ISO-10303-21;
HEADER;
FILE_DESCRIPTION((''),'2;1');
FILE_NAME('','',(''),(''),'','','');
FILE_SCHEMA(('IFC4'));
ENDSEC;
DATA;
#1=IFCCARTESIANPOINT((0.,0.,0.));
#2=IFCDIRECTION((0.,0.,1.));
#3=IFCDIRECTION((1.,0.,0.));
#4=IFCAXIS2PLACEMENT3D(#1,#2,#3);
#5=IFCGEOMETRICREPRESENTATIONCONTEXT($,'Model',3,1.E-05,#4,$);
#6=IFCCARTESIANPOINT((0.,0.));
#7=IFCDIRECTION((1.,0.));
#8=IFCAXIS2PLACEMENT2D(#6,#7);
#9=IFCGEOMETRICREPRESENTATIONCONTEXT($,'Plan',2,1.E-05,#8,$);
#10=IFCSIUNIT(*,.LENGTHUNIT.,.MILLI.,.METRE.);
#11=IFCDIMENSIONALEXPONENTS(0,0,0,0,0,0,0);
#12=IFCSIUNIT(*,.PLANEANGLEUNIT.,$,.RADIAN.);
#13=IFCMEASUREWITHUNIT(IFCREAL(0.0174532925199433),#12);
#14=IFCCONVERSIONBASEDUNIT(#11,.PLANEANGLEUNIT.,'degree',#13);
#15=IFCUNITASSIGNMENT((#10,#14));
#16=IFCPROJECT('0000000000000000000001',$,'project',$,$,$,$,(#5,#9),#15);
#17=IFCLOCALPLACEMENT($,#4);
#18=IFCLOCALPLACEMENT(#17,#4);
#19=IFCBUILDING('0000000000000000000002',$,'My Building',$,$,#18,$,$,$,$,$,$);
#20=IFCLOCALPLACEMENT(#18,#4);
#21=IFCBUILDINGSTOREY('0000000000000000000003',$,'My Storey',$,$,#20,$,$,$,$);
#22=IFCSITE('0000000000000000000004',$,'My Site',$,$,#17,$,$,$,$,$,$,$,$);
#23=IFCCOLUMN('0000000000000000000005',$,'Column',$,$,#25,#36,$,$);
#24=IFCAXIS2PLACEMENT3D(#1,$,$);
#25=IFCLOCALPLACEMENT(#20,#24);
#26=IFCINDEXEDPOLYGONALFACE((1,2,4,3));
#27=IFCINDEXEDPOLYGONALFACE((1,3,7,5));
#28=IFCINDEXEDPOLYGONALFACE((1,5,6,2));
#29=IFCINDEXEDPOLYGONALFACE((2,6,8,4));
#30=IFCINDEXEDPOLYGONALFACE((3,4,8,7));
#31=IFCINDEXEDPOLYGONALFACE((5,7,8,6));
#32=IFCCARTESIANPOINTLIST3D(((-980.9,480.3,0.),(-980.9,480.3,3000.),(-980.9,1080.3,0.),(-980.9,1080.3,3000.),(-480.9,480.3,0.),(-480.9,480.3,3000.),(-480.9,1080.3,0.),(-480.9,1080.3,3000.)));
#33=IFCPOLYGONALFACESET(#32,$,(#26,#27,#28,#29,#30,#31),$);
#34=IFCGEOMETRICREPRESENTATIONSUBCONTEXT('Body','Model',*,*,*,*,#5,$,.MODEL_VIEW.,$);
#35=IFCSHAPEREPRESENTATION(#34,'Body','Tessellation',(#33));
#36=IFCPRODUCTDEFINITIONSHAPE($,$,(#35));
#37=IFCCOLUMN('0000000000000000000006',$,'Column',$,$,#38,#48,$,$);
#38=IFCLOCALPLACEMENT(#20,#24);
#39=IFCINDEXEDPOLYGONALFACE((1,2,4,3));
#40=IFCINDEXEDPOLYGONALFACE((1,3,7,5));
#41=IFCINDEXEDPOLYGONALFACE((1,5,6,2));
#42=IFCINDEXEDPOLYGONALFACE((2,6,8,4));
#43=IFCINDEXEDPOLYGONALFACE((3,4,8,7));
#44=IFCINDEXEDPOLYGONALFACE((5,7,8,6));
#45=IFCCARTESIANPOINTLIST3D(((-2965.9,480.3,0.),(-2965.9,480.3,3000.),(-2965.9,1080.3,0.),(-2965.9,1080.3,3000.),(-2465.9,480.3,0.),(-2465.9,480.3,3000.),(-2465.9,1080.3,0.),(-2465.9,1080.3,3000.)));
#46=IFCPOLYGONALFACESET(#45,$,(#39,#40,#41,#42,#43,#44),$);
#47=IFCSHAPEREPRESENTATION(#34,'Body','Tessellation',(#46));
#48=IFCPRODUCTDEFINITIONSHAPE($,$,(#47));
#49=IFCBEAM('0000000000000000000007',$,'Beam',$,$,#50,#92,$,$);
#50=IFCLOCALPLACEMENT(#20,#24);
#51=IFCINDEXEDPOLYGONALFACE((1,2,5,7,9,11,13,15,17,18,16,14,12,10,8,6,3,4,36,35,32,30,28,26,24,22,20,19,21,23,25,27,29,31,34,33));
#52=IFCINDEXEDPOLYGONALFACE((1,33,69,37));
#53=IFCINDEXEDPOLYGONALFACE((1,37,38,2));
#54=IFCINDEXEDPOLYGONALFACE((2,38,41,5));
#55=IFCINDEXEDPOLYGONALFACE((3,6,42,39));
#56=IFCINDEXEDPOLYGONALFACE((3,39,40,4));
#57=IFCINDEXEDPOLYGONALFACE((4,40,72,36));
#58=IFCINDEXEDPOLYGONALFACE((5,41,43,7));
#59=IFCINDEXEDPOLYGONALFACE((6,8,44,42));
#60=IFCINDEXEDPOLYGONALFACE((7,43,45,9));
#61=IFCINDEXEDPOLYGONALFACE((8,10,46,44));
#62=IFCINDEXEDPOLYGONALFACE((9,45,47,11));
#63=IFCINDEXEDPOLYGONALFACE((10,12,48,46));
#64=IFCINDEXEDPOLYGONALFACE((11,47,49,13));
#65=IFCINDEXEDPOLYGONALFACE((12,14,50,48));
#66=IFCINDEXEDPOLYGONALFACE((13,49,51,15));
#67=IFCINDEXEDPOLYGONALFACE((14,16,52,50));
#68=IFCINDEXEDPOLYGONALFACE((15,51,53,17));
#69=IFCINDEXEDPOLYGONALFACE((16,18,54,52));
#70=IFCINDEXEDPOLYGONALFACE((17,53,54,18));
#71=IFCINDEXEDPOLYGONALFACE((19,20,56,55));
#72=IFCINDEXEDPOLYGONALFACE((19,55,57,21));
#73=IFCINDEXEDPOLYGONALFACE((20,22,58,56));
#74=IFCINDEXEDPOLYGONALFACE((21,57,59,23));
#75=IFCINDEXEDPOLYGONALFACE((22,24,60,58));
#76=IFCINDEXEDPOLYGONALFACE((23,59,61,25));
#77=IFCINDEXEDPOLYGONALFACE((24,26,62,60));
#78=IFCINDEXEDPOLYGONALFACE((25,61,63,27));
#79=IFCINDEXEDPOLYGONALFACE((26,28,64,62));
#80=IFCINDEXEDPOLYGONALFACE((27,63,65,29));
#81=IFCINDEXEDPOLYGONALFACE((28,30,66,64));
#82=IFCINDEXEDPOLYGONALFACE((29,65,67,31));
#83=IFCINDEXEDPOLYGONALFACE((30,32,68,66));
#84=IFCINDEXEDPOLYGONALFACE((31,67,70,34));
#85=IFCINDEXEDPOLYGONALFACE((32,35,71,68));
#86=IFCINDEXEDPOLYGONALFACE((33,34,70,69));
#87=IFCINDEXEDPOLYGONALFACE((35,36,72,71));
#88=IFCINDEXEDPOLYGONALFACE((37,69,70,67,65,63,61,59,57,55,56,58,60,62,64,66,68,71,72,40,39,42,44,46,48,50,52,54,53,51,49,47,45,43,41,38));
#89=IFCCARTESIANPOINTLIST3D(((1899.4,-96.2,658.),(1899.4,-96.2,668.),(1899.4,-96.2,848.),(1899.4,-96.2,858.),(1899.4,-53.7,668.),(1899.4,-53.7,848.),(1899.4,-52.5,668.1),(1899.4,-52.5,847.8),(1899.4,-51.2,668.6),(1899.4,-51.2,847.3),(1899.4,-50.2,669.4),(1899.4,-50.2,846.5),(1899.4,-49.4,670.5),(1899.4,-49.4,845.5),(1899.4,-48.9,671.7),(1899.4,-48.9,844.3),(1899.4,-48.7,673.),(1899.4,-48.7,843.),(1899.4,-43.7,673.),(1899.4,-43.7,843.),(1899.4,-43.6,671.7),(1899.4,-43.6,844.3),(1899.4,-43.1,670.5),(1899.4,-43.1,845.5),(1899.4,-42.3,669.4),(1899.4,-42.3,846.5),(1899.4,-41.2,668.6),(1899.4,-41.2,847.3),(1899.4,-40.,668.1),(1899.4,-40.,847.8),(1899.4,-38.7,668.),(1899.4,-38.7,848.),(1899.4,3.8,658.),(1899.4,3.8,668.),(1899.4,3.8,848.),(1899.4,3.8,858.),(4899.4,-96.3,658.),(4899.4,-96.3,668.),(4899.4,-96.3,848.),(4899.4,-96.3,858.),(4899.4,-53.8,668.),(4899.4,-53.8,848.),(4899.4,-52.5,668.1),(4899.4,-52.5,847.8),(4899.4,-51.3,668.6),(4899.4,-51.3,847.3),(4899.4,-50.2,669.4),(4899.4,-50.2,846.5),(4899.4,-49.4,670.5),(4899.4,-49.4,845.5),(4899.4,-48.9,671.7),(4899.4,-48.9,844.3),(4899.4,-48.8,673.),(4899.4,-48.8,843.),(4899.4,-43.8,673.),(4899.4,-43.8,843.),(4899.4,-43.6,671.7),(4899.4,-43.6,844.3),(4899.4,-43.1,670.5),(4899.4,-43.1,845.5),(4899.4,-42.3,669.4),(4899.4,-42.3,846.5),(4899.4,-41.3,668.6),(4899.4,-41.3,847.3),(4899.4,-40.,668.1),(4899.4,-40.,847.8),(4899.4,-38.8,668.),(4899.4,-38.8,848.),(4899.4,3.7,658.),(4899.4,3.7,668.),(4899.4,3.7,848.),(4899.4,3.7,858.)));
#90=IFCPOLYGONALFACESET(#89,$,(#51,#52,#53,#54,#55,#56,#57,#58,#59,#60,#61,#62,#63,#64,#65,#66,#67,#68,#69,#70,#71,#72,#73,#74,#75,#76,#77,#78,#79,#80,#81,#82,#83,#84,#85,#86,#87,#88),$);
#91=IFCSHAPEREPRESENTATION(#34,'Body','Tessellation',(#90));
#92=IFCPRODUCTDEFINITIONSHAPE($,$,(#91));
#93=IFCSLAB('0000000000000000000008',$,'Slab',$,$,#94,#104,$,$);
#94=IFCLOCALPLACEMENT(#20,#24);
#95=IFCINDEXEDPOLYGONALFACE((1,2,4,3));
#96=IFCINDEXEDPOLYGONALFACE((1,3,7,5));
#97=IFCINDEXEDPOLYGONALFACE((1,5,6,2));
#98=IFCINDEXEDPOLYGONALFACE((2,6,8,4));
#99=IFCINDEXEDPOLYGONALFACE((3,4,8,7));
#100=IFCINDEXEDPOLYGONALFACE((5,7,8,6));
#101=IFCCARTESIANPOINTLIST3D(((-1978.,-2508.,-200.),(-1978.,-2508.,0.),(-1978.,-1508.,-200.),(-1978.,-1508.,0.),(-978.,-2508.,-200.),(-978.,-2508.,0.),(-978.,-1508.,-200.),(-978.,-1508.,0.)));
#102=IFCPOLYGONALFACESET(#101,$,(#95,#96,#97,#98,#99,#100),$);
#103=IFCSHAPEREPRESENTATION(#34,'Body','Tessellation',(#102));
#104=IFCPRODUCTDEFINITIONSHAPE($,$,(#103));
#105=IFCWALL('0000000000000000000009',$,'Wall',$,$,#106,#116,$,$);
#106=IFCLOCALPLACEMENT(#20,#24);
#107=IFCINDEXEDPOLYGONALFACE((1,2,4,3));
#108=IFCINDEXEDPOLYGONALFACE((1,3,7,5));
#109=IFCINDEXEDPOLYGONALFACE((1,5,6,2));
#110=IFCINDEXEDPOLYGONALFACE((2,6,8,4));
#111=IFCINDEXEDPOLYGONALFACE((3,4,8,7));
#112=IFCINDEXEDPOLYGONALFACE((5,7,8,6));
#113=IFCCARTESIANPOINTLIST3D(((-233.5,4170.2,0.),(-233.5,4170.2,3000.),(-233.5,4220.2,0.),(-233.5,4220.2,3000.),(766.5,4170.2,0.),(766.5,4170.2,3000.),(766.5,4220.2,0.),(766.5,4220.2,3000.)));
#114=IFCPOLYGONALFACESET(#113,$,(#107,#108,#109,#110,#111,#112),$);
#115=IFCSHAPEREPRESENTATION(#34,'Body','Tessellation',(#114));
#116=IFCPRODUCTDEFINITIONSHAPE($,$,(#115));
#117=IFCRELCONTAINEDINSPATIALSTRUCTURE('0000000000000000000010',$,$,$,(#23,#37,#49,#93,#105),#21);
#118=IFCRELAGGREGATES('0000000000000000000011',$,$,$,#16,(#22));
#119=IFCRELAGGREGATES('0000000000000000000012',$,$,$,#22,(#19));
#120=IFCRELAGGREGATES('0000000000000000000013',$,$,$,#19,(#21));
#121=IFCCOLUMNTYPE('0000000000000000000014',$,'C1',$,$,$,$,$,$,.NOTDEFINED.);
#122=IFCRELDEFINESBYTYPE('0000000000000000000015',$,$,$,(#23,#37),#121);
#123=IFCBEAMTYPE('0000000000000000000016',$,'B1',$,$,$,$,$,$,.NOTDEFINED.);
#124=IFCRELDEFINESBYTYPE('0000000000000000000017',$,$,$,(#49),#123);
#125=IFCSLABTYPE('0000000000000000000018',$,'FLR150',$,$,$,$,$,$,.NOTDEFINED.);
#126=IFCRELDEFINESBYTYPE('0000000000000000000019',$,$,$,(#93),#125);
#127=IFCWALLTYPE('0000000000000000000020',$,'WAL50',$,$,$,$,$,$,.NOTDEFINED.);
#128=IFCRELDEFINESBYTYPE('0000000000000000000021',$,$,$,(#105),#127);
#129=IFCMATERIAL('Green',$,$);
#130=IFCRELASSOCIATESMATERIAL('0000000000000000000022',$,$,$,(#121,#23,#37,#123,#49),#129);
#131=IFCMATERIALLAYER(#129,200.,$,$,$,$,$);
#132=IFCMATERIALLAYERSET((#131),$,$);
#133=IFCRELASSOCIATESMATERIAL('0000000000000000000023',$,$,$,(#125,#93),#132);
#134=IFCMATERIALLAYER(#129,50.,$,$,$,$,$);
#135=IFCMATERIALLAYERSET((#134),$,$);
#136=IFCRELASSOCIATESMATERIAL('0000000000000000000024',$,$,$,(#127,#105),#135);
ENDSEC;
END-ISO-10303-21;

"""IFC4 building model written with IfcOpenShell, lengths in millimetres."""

from ifc_helpers import new_model, entity, si_unit, converted_unit, frame, origin_with_axes, origin_2d_with_axis, place, context, subcontext, project, spatial, indexed_curve, rectangle, i_section, outline, extrude, material, layer, layer_set, layer_usage, material_profile, profile_set, profile_usage, type_object, element, save


model = new_model("IFC4")

# Units and contexts
model_context = context("Model", 3, precision=1e-05, world=origin_with_axes())
plan_context = context("Plan", 2, precision=1e-05, world=origin_2d_with_axis())
body_context = subcontext(model_context, "Body", "Model", "MODEL_VIEW")
ifc_project = project(units=[si_unit("LENGTHUNIT", "METRE", prefix="MILLI"), converted_unit("PLANEANGLEUNIT", "degree", entity("IfcReal", 0.0174532925199433), si_unit("PLANEANGLEUNIT", "RADIAN"), dimensions=[0, 0, 0, 0, 0, 0, 0])], contexts=[model_context, plan_context])

# Site, building, storey
site_placement = place(None, origin_with_axes())
site = spatial("IfcSite", under=ifc_project, at=site_placement, Name="My Site")
building_placement = place(site_placement, origin_with_axes())
building = spatial("IfcBuilding", under=site, at=building_placement, Name="My Building")
storey_placement = place(building_placement, origin_with_axes())
storey = spatial("IfcBuildingStorey", under=building, at=storey_placement, Name="My Storey")

# Columns
ifc_material = material(Name="Green")
ifc_material_profile_1 = material_profile(ifc_material, rectangle(XDim=500.0, YDim=600.0))
ifc_profile_set_1 = profile_set([ifc_material_profile_1])
ifc_profile_usage_1 = profile_usage(ifc_profile_set_1, cardinal=5)
column_type = type_object("IfcColumnType", Name="C1", PredefinedType="NOTDEFINED", material=ifc_profile_set_1)
column_1_placement = place(storey_placement, frame((-730.9, 780.3, 0.0), z_axis=(0.0, 0.0, 1.0), x_axis=(1.0, 0.0, 0.0)))
element("IfcColumn", 1, at=column_1_placement, inside=storey, type_object=column_type, material=ifc_profile_usage_1, Name="Column", context=body_context, shape_type="SweptSolid", body=[
    extrude(rectangle(XDim=500.0, YDim=600.0), origin_with_axes(), (0.0, 0.0, 1.0), 3000.0),
])
ifc_profile_usage_2 = profile_usage(ifc_profile_set_1, cardinal=5)
column_2_placement = place(storey_placement, frame((-2715.9, 780.3, 0.0), z_axis=(0.0, 0.0, 1.0), x_axis=(1.0, 0.0, 0.0)))
element("IfcColumn", 2, at=column_2_placement, inside=storey, type_object=column_type, material=ifc_profile_usage_2, Name="Column", context=body_context, shape_type="SweptSolid", body=[
    extrude(rectangle(XDim=500.0, YDim=600.0), origin_with_axes(), (0.0, 0.0, 1.0), 3000.0),
])

# Beam
ifc_material_profile_2 = material_profile(ifc_material, i_section(OverallWidth=100.0, OverallDepth=200.0, WebThickness=5.0, FlangeThickness=10.0, FilletRadius=5.0))
ifc_profile_set_2 = profile_set([ifc_material_profile_2])
ifc_profile_usage_3 = profile_usage(ifc_profile_set_2, cardinal=5)
beam_type = type_object("IfcBeamType", Name="B1", PredefinedType="NOTDEFINED", material=ifc_profile_set_2)
beam_placement = place(storey_placement, frame((1899.4, -46.2, 758.0), z_axis=(1.0, 0.0, 0.0), x_axis=(0.0, 1.0, 0.0)))
element("IfcBeam", 3, at=beam_placement, inside=storey, type_object=beam_type, material=ifc_profile_usage_3, Name="Beam", context=body_context, shape_type="SweptSolid", body=[
    extrude(i_section(OverallWidth=100.0, OverallDepth=200.0, WebThickness=5.0, FlangeThickness=10.0, FilletRadius=5.0), origin_with_axes(), (0.0, 0.0, 1.0), 3000.0),
])

# Slab
ifc_layer_1 = layer(ifc_material, 200.0)
ifc_layer_set_1 = layer_set([ifc_layer_1])
ifc_layer_usage_1 = layer_usage(ifc_layer_set_1, "AXIS3", "POSITIVE", 0.0)
slab_type = type_object("IfcSlabType", Name="FLR150", PredefinedType="NOTDEFINED", material=ifc_layer_set_1)
slab_placement = place(storey_placement, frame((-1978.0, -2508.0, -200.0), z_axis=(0.0, 0.0, 1.0), x_axis=(1.0, 0.0, 0.0)))
element("IfcSlab", 4, at=slab_placement, inside=storey, type_object=slab_type, material=ifc_layer_usage_1, Name="Slab", context=body_context, shape_type="SweptSolid", body=[
    extrude(outline(indexed_curve([(0.0, 0.0), (1000.0, 0.0), (1000.0, 1000.0), (0.0, 1000.0), (0.0, 0.0)])), None, (0.0, 0.0, 1.0), 200.0),
])

# Wall
ifc_layer_2 = layer(ifc_material, 50.0)
ifc_layer_set_2 = layer_set([ifc_layer_2])
ifc_layer_usage_2 = layer_usage(ifc_layer_set_2, "AXIS2", "POSITIVE", 0.0)
wall_type = type_object("IfcWallType", Name="WAL50", PredefinedType="NOTDEFINED", material=ifc_layer_set_2)
wall_placement = place(storey_placement, frame((-233.5, 4170.2, 0.0), z_axis=(0.0, 0.0, 1.0), x_axis=(1.0, 0.0, 0.0)))
element("IfcWall", 5, at=wall_placement, inside=storey, type_object=wall_type, material=ifc_layer_usage_2, Name="Wall", context=body_context, shape_type="SweptSolid", body=[
    extrude(outline(indexed_curve([(0.0, 0.0), (0.0, 50.0), (1000.0, 50.0), (1000.0, 0.0), (0.0, 0.0)], self_intersect=False)), origin_with_axes(), (0.0, 0.0, 1.0), 3000.0),
])

save(model, "model.ifc")
